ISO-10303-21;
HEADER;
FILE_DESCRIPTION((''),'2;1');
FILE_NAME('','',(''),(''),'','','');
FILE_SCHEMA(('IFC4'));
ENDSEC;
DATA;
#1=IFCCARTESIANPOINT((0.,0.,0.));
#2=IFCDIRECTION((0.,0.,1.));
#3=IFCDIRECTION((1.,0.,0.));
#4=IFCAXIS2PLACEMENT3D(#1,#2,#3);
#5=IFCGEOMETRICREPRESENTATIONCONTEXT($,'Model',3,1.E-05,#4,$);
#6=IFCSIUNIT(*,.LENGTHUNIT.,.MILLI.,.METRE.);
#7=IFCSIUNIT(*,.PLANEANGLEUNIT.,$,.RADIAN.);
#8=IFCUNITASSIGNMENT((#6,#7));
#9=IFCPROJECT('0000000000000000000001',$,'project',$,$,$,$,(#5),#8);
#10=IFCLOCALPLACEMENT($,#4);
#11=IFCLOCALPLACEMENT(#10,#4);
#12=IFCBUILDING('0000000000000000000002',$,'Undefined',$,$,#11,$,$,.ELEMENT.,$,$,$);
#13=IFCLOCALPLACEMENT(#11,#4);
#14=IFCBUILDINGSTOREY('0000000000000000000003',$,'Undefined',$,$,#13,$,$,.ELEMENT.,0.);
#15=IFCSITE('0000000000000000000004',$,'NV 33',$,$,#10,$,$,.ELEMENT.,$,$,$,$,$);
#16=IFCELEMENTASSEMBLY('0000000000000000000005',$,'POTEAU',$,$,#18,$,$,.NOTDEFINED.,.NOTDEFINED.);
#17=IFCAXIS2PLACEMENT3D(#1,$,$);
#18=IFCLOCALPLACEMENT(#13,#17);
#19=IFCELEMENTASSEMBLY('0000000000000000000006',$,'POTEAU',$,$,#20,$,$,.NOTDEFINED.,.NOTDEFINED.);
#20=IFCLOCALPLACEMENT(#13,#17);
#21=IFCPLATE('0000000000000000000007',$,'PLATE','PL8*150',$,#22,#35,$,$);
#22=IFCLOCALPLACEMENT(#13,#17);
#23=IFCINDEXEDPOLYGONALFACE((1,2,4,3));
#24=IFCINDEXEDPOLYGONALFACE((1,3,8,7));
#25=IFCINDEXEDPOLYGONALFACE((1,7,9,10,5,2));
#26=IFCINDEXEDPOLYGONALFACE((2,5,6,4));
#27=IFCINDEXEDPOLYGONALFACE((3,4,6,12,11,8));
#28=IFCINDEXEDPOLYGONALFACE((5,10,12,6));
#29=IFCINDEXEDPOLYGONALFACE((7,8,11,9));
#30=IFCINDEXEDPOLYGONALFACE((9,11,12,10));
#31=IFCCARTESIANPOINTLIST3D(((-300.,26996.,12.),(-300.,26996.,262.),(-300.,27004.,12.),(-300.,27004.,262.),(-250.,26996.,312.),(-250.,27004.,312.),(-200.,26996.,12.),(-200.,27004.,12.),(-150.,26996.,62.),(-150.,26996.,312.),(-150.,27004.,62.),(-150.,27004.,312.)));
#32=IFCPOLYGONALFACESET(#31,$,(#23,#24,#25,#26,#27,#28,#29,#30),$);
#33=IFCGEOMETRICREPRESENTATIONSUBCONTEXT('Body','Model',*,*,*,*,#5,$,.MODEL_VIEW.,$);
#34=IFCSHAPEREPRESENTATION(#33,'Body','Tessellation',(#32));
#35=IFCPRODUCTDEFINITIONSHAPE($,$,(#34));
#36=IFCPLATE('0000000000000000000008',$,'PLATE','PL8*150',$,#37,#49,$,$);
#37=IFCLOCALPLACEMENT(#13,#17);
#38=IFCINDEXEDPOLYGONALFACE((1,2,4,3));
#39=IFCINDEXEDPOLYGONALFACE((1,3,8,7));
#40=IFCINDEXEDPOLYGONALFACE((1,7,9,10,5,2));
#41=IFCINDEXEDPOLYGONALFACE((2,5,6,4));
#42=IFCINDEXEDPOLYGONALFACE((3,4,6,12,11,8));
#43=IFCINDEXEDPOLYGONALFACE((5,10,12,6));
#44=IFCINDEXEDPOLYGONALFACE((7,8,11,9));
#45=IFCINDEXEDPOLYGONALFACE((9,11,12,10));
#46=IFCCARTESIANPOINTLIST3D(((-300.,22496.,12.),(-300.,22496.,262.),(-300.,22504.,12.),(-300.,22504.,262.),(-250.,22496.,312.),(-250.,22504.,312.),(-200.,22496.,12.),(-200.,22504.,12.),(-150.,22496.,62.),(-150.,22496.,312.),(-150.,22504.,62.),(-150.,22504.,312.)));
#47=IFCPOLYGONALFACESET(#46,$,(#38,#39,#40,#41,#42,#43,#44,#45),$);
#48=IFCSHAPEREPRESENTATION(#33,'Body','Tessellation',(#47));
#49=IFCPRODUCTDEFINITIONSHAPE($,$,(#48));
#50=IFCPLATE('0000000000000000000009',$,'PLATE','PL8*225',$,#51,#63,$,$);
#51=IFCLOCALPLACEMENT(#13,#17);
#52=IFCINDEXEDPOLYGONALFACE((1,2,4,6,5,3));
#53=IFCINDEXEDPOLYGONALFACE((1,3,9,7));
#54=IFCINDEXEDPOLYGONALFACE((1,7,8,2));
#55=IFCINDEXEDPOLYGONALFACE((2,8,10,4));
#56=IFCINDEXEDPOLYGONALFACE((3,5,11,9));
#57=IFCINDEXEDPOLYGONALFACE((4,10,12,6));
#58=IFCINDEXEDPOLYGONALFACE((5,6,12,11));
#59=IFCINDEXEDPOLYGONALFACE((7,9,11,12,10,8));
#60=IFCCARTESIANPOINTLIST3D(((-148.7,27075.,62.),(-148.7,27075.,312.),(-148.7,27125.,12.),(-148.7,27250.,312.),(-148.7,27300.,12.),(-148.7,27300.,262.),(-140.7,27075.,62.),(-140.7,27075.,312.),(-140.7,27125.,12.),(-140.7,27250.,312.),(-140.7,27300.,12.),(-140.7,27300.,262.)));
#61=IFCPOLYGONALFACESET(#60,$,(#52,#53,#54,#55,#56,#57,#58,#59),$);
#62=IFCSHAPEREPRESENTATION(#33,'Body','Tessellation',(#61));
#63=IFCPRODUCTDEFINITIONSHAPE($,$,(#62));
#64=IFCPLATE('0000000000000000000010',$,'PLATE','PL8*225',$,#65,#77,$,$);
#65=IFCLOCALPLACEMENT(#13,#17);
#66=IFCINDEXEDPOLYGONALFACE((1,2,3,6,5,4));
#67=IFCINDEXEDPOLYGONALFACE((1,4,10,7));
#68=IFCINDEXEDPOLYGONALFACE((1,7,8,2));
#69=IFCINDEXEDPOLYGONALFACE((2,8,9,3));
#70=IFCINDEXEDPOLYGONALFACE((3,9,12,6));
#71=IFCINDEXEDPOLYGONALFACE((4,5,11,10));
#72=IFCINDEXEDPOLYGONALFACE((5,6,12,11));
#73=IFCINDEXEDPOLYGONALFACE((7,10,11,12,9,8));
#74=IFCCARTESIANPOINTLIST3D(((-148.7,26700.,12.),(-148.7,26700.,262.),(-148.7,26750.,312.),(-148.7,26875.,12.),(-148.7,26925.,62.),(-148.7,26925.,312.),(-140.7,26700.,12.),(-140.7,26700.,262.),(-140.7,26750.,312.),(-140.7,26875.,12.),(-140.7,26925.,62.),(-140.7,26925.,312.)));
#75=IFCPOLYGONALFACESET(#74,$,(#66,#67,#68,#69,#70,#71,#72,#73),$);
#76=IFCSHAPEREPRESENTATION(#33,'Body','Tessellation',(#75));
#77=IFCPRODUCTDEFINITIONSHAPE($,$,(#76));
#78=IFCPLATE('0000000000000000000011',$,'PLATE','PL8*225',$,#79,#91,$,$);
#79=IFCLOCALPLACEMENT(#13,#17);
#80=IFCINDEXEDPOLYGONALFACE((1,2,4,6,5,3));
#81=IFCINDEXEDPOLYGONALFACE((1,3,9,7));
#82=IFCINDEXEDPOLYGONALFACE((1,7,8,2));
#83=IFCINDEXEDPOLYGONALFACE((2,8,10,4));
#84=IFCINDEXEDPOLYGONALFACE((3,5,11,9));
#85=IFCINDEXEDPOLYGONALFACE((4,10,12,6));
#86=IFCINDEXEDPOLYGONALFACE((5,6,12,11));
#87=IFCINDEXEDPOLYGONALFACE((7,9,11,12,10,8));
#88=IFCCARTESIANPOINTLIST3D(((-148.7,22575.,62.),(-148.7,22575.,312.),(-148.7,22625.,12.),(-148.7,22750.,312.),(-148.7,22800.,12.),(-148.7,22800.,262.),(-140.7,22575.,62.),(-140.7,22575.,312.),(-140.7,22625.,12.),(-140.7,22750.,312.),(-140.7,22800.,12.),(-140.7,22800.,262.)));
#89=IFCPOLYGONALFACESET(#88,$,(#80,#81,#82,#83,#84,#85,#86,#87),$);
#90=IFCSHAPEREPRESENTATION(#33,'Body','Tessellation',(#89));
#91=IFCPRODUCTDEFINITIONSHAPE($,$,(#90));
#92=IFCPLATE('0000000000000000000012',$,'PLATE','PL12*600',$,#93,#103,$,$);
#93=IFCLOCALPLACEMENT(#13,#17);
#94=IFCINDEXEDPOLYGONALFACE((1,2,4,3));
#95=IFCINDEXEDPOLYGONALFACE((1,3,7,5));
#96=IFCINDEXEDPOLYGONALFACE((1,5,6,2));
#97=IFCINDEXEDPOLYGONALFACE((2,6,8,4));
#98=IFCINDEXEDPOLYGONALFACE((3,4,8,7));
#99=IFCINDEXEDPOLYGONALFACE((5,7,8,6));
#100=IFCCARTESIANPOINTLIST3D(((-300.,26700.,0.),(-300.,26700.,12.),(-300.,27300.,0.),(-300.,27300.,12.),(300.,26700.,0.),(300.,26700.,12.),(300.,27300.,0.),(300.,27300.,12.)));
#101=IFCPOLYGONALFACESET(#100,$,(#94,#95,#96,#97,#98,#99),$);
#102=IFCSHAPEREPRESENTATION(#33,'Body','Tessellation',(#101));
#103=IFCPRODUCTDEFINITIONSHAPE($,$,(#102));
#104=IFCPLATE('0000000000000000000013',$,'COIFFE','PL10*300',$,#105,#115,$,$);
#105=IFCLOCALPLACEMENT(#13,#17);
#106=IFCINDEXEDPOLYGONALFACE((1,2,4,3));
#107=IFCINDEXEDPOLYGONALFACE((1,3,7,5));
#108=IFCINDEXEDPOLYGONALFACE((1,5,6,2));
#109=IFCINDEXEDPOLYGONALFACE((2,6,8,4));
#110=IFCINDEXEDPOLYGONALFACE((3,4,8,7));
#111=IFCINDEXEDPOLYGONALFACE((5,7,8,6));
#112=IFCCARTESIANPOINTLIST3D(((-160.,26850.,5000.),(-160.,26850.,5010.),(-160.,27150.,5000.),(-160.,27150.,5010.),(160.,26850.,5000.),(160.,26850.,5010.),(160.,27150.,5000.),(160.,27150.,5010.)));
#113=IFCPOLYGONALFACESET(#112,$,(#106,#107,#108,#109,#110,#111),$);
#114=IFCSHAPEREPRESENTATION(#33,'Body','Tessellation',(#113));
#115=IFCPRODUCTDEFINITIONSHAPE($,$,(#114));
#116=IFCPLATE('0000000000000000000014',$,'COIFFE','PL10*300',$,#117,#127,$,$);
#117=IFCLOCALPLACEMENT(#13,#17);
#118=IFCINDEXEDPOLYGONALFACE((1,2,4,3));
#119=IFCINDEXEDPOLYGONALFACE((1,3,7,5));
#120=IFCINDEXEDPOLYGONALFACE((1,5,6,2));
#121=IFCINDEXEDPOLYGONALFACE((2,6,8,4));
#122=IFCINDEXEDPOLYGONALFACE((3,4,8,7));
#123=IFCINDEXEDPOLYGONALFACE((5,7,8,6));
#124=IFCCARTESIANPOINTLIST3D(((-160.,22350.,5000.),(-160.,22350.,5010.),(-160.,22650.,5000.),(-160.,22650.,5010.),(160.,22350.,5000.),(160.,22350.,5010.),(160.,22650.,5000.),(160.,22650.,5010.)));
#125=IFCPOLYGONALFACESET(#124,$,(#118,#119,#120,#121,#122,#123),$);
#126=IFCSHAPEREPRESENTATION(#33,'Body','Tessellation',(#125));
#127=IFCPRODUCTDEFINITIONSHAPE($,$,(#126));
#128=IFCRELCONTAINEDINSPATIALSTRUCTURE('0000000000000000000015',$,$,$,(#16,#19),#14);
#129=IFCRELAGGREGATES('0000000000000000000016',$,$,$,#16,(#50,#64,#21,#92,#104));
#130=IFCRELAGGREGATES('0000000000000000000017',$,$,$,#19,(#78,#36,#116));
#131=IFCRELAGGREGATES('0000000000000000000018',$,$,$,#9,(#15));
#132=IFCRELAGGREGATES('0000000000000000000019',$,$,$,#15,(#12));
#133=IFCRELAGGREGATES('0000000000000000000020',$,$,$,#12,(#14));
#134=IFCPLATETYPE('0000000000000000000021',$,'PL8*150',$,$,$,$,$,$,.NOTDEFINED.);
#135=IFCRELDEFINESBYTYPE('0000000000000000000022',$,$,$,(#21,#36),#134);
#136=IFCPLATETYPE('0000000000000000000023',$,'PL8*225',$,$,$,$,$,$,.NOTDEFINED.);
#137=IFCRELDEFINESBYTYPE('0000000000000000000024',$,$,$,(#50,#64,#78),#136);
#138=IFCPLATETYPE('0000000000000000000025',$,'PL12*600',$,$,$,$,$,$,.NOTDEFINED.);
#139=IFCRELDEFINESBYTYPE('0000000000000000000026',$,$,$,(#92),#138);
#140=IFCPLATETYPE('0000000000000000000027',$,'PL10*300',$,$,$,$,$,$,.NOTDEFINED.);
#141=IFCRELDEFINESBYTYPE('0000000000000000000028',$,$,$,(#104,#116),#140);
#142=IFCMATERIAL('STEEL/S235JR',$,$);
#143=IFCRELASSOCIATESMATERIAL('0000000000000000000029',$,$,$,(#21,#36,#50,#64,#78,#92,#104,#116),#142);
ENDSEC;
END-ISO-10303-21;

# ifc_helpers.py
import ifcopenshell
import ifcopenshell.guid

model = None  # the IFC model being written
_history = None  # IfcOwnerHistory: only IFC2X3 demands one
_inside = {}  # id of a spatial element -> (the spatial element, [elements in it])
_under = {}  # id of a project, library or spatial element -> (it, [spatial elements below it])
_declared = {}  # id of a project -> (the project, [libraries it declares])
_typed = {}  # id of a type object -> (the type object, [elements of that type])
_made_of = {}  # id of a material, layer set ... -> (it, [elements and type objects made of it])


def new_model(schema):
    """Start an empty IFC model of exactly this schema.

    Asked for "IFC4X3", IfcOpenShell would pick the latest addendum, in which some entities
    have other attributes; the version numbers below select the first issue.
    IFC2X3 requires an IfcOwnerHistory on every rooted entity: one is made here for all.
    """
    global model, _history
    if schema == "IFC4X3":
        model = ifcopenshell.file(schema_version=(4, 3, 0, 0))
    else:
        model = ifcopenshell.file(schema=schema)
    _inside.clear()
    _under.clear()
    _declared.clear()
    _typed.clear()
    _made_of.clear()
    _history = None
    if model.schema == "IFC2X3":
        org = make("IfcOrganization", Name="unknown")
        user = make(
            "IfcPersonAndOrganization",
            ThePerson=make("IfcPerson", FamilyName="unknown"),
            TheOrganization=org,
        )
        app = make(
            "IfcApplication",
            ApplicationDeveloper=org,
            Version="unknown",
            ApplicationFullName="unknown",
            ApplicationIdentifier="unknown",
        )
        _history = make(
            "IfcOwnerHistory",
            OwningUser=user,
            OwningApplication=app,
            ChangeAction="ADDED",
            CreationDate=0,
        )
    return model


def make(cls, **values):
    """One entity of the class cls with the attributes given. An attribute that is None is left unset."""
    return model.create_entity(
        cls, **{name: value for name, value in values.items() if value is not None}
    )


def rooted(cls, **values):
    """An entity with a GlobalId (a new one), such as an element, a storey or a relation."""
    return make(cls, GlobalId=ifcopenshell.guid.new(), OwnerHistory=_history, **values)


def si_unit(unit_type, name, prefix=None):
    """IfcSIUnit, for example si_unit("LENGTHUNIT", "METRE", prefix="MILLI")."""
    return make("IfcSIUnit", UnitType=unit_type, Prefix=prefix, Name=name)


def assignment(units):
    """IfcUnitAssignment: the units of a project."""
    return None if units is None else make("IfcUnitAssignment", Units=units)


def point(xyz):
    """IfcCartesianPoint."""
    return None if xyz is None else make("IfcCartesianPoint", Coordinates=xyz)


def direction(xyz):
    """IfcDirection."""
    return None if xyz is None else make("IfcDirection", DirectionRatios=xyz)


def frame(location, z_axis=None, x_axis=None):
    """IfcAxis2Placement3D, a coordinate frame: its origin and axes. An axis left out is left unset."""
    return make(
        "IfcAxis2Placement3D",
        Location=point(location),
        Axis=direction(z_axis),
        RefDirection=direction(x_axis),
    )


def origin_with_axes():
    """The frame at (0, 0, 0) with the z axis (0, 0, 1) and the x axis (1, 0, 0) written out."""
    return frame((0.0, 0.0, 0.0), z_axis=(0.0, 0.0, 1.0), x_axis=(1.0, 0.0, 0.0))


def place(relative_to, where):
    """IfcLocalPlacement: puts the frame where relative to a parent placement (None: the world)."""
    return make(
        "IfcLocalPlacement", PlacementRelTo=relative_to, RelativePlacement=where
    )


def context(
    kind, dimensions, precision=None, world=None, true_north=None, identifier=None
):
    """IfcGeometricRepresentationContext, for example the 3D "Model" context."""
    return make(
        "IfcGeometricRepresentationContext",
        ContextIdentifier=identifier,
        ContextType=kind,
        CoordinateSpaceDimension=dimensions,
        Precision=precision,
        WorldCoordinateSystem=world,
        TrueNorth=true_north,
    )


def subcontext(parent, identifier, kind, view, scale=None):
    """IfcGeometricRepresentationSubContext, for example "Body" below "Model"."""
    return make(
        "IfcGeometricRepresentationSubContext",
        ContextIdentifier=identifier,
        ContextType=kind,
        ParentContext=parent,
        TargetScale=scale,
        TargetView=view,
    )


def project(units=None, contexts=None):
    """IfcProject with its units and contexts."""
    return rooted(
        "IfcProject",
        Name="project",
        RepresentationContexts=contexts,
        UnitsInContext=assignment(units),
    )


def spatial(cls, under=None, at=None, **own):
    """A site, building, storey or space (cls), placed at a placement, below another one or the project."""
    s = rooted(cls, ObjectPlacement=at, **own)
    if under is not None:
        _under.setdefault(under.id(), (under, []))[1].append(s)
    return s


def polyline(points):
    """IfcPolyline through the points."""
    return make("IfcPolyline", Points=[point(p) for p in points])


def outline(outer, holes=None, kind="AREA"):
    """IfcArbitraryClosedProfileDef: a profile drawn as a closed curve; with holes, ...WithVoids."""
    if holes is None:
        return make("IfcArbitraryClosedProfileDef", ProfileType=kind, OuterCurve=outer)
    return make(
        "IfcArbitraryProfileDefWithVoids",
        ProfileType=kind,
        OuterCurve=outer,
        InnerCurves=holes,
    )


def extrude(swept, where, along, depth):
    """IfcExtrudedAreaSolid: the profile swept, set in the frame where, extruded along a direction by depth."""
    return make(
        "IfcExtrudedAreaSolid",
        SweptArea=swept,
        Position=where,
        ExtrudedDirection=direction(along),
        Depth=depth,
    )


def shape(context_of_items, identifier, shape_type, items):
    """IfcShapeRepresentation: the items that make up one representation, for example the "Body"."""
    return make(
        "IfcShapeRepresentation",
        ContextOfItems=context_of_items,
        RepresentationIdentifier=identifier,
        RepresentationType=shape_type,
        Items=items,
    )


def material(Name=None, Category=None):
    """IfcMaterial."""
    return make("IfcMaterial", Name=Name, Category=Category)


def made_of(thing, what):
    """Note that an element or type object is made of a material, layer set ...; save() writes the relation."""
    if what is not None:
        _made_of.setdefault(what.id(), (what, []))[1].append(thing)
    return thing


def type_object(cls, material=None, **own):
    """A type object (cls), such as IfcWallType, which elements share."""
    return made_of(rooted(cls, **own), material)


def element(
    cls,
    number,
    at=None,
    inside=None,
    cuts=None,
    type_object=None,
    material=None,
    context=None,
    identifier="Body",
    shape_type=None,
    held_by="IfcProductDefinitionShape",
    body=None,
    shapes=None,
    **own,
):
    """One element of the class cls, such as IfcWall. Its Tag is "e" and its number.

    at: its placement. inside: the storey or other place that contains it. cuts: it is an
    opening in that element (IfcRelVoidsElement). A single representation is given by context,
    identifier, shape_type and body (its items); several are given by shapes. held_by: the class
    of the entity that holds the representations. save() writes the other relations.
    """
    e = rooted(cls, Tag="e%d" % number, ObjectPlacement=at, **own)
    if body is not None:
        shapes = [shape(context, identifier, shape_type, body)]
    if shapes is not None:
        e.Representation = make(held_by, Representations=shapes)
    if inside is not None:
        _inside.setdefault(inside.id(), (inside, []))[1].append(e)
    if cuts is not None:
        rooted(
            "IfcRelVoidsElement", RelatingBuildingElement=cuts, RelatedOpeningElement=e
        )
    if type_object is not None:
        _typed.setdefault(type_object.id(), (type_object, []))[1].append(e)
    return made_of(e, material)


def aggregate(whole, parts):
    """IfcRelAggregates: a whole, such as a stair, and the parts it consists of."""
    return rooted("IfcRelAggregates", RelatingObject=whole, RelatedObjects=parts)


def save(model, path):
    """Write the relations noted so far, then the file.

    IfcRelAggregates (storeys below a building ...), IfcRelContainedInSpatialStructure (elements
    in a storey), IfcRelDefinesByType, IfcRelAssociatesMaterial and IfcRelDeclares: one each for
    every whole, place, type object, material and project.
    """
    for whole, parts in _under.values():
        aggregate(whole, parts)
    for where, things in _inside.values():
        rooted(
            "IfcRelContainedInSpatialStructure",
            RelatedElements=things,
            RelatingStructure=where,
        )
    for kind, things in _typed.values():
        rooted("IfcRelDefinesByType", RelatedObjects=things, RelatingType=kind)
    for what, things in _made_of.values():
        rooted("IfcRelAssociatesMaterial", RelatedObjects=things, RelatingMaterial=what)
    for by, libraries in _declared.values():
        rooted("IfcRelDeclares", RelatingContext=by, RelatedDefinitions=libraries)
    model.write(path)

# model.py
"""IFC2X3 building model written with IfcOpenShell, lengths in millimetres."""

from ifc_helpers import new_model, si_unit, frame, origin_with_axes, place, context, subcontext, project, spatial, polyline, outline, extrude, material, type_object, element, aggregate, save


model = new_model("IFC2X3")

# Units and contexts
model_context = context("Model", 3, precision=1e-05, world=origin_with_axes())
body_context = subcontext(model_context, "Body", "Model", "MODEL_VIEW")
ifc_project = project(units=[si_unit("LENGTHUNIT", "METRE", prefix="MILLI"), si_unit("PLANEANGLEUNIT", "RADIAN")], contexts=[model_context])

# Site, building, storey
site_placement = place(None, origin_with_axes())
site = spatial("IfcSite", under=ifc_project, at=site_placement, Name="NV 33", CompositionType="ELEMENT")
building_placement = place(site_placement, origin_with_axes())
building = spatial("IfcBuilding", under=site, at=building_placement, Name="Undefined", CompositionType="ELEMENT")
storey_placement = place(building_placement, origin_with_axes())
storey = spatial("IfcBuildingStorey", under=building, at=storey_placement, Name="Undefined", CompositionType="ELEMENT", Elevation=0.0)

# Shared definitions
ifc_material_1 = material(Name="STEEL/S235JR")

# Element assemblies
assembly_1_placement = place(storey_placement, origin_with_axes())
assembly_1 = element("IfcElementAssembly", 1, at=assembly_1_placement, inside=storey, Name="POTEAU", AssemblyPlace="NOTDEFINED", PredefinedType="NOTDEFINED")
assembly_2_placement = place(storey_placement, origin_with_axes())
assembly_2 = element("IfcElementAssembly", 2, at=assembly_2_placement, inside=storey, Name="POTEAU", AssemblyPlace="NOTDEFINED", PredefinedType="NOTDEFINED")

# Plates
plate_type_1 = type_object("IfcPlateType", Name="PL8*150", PredefinedType="NOTDEFINED")
plate_1_placement = place(assembly_1_placement, frame((-150.0, 27000.0, 12.0), z_axis=(0.0, 1.0, 0.0), x_axis=(-1.0, 0.0, 0.0)))
plate_1 = element("IfcPlate", 3, at=plate_1_placement, type_object=plate_type_1, material=ifc_material_1, Name="PLATE", Description="PL8*150", context=body_context, shape_type="SweptSolid", body=[
    extrude(outline(polyline([(0.0, 50.0), (50.0, 0.0), (150.0, 0.0), (150.0, 250.0), (100.0, 300.0), (0.0, 300.0), (0.0, 50.0)])), frame((0.0, 0.0, -4.0), z_axis=(0.0, 0.0, 1.0), x_axis=(1.0, 0.0, 0.0)), (0.0, 0.0, 1.0), 8.0),
])
plate_2_placement = place(assembly_2_placement, frame((-150.0, 22500.0, 12.0), z_axis=(0.0, 1.0, 0.0), x_axis=(-1.0, 0.0, 0.0)))
plate_2 = element("IfcPlate", 4, at=plate_2_placement, type_object=plate_type_1, material=ifc_material_1, Name="PLATE", Description="PL8*150", context=body_context, shape_type="SweptSolid", body=[
    extrude(outline(polyline([(0.0, 50.0), (50.0, 0.0), (150.0, 0.0), (150.0, 250.0), (100.0, 300.0), (0.0, 300.0), (0.0, 50.0)])), frame((0.0, 0.0, -4.0), z_axis=(0.0, 0.0, 1.0), x_axis=(1.0, 0.0, 0.0)), (0.0, 0.0, 1.0), 8.0),
])
plate_type_2 = type_object("IfcPlateType", Name="PL8*225", PredefinedType="NOTDEFINED")
plate_3_placement = place(assembly_1_placement, frame((-144.7, 27075.0, 12.0), z_axis=(1.0, 0.0, 0.0), x_axis=(0.0, 1.0, 0.0)))
plate_3 = element("IfcPlate", 5, at=plate_3_placement, type_object=plate_type_2, material=ifc_material_1, Name="PLATE", Description="PL8*225", context=body_context, shape_type="SweptSolid", body=[
    extrude(outline(polyline([(0.0, 50.0), (50.0, 0.0), (225.0, 0.0), (225.0, 250.0), (175.0, 300.0), (0.0, 300.0), (0.0, 50.0)])), frame((0.0, 0.0, -4.0), z_axis=(0.0, 0.0, 1.0), x_axis=(1.0, 0.0, 0.0)), (0.0, 0.0, 1.0), 8.0),
])
plate_4_placement = place(assembly_1_placement, frame((-144.7, 26925.0, 12.0), z_axis=(-1.0, 0.0, 0.0), x_axis=(0.0, -1.0, 0.0)))
plate_4 = element("IfcPlate", 6, at=plate_4_placement, type_object=plate_type_2, material=ifc_material_1, Name="PLATE", Description="PL8*225", context=body_context, shape_type="SweptSolid", body=[
    extrude(outline(polyline([(0.0, 50.0), (50.0, 0.0), (225.0, 0.0), (225.0, 250.0), (175.0, 300.0), (0.0, 300.0), (0.0, 50.0)])), frame((0.0, 0.0, -4.0), z_axis=(0.0, 0.0, 1.0), x_axis=(1.0, 0.0, 0.0)), (0.0, 0.0, 1.0), 8.0),
])
plate_5_placement = place(assembly_2_placement, frame((-144.7, 22575.0, 12.0), z_axis=(1.0, 0.0, 0.0), x_axis=(0.0, 1.0, 0.0)))
plate_5 = element("IfcPlate", 7, at=plate_5_placement, type_object=plate_type_2, material=ifc_material_1, Name="PLATE", Description="PL8*225", context=body_context, shape_type="SweptSolid", body=[
    extrude(outline(polyline([(0.0, 50.0), (50.0, 0.0), (225.0, 0.0), (225.0, 250.0), (175.0, 300.0), (0.0, 300.0), (0.0, 50.0)])), frame((0.0, 0.0, -4.0), z_axis=(0.0, 0.0, 1.0), x_axis=(1.0, 0.0, 0.0)), (0.0, 0.0, 1.0), 8.0),
])
plate_type_3 = type_object("IfcPlateType", Name="PL12*600", PredefinedType="NOTDEFINED")
plate_6_placement = place(assembly_1_placement, frame((-300.0, 26700.0, 6.0), z_axis=(0.0, 0.0, 1.0), x_axis=(1.0, 0.0, 0.0)))
plate_6 = element("IfcPlate", 8, at=plate_6_placement, type_object=plate_type_3, material=ifc_material_1, Name="PLATE", Description="PL12*600", context=body_context, shape_type="SweptSolid", body=[
    extrude(outline(polyline([(0.0, 0.0), (600.0, 0.0), (600.0, 600.0), (0.0, 600.0), (0.0, 0.0)])), frame((0.0, 0.0, -6.0), z_axis=(0.0, 0.0, 1.0), x_axis=(1.0, 0.0, 0.0)), (0.0, 0.0, 1.0), 12.0),
])
plate_type_4 = type_object("IfcPlateType", Name="PL10*300", PredefinedType="NOTDEFINED")
plate_7_placement = place(assembly_1_placement, frame((-160.0, 27150.0, 5005.0), z_axis=(0.0, 0.0, 1.0), x_axis=(0.0, -1.0, 0.0)))
plate_7 = element("IfcPlate", 9, at=plate_7_placement, type_object=plate_type_4, material=ifc_material_1, Name="COIFFE", Description="PL10*300", context=body_context, shape_type="SweptSolid", body=[
    extrude(outline(polyline([(0.0, 0.0), (300.0, 0.0), (300.0, 320.0), (0.0, 320.0), (0.0, 0.0)])), frame((0.0, 0.0, -5.0), z_axis=(0.0, 0.0, 1.0), x_axis=(1.0, 0.0, 0.0)), (0.0, 0.0, 1.0), 10.0),
])
plate_8_placement = place(assembly_2_placement, frame((-160.0, 22650.0, 5005.0), z_axis=(0.0, 0.0, 1.0), x_axis=(0.0, -1.0, 0.0)))
plate_8 = element("IfcPlate", 10, at=plate_8_placement, type_object=plate_type_4, material=ifc_material_1, Name="COIFFE", Description="PL10*300", context=body_context, shape_type="SweptSolid", body=[
    extrude(outline(polyline([(0.0, 0.0), (300.0, 0.0), (300.0, 320.0), (0.0, 320.0), (0.0, 0.0)])), frame((0.0, 0.0, -5.0), z_axis=(0.0, 0.0, 1.0), x_axis=(1.0, 0.0, 0.0)), (0.0, 0.0, 1.0), 10.0),
])

aggregate(assembly_1, [plate_3, plate_4, plate_1, plate_6, plate_7])
aggregate(assembly_2, [plate_5, plate_2, plate_8])

save(model, "model.ifc")
